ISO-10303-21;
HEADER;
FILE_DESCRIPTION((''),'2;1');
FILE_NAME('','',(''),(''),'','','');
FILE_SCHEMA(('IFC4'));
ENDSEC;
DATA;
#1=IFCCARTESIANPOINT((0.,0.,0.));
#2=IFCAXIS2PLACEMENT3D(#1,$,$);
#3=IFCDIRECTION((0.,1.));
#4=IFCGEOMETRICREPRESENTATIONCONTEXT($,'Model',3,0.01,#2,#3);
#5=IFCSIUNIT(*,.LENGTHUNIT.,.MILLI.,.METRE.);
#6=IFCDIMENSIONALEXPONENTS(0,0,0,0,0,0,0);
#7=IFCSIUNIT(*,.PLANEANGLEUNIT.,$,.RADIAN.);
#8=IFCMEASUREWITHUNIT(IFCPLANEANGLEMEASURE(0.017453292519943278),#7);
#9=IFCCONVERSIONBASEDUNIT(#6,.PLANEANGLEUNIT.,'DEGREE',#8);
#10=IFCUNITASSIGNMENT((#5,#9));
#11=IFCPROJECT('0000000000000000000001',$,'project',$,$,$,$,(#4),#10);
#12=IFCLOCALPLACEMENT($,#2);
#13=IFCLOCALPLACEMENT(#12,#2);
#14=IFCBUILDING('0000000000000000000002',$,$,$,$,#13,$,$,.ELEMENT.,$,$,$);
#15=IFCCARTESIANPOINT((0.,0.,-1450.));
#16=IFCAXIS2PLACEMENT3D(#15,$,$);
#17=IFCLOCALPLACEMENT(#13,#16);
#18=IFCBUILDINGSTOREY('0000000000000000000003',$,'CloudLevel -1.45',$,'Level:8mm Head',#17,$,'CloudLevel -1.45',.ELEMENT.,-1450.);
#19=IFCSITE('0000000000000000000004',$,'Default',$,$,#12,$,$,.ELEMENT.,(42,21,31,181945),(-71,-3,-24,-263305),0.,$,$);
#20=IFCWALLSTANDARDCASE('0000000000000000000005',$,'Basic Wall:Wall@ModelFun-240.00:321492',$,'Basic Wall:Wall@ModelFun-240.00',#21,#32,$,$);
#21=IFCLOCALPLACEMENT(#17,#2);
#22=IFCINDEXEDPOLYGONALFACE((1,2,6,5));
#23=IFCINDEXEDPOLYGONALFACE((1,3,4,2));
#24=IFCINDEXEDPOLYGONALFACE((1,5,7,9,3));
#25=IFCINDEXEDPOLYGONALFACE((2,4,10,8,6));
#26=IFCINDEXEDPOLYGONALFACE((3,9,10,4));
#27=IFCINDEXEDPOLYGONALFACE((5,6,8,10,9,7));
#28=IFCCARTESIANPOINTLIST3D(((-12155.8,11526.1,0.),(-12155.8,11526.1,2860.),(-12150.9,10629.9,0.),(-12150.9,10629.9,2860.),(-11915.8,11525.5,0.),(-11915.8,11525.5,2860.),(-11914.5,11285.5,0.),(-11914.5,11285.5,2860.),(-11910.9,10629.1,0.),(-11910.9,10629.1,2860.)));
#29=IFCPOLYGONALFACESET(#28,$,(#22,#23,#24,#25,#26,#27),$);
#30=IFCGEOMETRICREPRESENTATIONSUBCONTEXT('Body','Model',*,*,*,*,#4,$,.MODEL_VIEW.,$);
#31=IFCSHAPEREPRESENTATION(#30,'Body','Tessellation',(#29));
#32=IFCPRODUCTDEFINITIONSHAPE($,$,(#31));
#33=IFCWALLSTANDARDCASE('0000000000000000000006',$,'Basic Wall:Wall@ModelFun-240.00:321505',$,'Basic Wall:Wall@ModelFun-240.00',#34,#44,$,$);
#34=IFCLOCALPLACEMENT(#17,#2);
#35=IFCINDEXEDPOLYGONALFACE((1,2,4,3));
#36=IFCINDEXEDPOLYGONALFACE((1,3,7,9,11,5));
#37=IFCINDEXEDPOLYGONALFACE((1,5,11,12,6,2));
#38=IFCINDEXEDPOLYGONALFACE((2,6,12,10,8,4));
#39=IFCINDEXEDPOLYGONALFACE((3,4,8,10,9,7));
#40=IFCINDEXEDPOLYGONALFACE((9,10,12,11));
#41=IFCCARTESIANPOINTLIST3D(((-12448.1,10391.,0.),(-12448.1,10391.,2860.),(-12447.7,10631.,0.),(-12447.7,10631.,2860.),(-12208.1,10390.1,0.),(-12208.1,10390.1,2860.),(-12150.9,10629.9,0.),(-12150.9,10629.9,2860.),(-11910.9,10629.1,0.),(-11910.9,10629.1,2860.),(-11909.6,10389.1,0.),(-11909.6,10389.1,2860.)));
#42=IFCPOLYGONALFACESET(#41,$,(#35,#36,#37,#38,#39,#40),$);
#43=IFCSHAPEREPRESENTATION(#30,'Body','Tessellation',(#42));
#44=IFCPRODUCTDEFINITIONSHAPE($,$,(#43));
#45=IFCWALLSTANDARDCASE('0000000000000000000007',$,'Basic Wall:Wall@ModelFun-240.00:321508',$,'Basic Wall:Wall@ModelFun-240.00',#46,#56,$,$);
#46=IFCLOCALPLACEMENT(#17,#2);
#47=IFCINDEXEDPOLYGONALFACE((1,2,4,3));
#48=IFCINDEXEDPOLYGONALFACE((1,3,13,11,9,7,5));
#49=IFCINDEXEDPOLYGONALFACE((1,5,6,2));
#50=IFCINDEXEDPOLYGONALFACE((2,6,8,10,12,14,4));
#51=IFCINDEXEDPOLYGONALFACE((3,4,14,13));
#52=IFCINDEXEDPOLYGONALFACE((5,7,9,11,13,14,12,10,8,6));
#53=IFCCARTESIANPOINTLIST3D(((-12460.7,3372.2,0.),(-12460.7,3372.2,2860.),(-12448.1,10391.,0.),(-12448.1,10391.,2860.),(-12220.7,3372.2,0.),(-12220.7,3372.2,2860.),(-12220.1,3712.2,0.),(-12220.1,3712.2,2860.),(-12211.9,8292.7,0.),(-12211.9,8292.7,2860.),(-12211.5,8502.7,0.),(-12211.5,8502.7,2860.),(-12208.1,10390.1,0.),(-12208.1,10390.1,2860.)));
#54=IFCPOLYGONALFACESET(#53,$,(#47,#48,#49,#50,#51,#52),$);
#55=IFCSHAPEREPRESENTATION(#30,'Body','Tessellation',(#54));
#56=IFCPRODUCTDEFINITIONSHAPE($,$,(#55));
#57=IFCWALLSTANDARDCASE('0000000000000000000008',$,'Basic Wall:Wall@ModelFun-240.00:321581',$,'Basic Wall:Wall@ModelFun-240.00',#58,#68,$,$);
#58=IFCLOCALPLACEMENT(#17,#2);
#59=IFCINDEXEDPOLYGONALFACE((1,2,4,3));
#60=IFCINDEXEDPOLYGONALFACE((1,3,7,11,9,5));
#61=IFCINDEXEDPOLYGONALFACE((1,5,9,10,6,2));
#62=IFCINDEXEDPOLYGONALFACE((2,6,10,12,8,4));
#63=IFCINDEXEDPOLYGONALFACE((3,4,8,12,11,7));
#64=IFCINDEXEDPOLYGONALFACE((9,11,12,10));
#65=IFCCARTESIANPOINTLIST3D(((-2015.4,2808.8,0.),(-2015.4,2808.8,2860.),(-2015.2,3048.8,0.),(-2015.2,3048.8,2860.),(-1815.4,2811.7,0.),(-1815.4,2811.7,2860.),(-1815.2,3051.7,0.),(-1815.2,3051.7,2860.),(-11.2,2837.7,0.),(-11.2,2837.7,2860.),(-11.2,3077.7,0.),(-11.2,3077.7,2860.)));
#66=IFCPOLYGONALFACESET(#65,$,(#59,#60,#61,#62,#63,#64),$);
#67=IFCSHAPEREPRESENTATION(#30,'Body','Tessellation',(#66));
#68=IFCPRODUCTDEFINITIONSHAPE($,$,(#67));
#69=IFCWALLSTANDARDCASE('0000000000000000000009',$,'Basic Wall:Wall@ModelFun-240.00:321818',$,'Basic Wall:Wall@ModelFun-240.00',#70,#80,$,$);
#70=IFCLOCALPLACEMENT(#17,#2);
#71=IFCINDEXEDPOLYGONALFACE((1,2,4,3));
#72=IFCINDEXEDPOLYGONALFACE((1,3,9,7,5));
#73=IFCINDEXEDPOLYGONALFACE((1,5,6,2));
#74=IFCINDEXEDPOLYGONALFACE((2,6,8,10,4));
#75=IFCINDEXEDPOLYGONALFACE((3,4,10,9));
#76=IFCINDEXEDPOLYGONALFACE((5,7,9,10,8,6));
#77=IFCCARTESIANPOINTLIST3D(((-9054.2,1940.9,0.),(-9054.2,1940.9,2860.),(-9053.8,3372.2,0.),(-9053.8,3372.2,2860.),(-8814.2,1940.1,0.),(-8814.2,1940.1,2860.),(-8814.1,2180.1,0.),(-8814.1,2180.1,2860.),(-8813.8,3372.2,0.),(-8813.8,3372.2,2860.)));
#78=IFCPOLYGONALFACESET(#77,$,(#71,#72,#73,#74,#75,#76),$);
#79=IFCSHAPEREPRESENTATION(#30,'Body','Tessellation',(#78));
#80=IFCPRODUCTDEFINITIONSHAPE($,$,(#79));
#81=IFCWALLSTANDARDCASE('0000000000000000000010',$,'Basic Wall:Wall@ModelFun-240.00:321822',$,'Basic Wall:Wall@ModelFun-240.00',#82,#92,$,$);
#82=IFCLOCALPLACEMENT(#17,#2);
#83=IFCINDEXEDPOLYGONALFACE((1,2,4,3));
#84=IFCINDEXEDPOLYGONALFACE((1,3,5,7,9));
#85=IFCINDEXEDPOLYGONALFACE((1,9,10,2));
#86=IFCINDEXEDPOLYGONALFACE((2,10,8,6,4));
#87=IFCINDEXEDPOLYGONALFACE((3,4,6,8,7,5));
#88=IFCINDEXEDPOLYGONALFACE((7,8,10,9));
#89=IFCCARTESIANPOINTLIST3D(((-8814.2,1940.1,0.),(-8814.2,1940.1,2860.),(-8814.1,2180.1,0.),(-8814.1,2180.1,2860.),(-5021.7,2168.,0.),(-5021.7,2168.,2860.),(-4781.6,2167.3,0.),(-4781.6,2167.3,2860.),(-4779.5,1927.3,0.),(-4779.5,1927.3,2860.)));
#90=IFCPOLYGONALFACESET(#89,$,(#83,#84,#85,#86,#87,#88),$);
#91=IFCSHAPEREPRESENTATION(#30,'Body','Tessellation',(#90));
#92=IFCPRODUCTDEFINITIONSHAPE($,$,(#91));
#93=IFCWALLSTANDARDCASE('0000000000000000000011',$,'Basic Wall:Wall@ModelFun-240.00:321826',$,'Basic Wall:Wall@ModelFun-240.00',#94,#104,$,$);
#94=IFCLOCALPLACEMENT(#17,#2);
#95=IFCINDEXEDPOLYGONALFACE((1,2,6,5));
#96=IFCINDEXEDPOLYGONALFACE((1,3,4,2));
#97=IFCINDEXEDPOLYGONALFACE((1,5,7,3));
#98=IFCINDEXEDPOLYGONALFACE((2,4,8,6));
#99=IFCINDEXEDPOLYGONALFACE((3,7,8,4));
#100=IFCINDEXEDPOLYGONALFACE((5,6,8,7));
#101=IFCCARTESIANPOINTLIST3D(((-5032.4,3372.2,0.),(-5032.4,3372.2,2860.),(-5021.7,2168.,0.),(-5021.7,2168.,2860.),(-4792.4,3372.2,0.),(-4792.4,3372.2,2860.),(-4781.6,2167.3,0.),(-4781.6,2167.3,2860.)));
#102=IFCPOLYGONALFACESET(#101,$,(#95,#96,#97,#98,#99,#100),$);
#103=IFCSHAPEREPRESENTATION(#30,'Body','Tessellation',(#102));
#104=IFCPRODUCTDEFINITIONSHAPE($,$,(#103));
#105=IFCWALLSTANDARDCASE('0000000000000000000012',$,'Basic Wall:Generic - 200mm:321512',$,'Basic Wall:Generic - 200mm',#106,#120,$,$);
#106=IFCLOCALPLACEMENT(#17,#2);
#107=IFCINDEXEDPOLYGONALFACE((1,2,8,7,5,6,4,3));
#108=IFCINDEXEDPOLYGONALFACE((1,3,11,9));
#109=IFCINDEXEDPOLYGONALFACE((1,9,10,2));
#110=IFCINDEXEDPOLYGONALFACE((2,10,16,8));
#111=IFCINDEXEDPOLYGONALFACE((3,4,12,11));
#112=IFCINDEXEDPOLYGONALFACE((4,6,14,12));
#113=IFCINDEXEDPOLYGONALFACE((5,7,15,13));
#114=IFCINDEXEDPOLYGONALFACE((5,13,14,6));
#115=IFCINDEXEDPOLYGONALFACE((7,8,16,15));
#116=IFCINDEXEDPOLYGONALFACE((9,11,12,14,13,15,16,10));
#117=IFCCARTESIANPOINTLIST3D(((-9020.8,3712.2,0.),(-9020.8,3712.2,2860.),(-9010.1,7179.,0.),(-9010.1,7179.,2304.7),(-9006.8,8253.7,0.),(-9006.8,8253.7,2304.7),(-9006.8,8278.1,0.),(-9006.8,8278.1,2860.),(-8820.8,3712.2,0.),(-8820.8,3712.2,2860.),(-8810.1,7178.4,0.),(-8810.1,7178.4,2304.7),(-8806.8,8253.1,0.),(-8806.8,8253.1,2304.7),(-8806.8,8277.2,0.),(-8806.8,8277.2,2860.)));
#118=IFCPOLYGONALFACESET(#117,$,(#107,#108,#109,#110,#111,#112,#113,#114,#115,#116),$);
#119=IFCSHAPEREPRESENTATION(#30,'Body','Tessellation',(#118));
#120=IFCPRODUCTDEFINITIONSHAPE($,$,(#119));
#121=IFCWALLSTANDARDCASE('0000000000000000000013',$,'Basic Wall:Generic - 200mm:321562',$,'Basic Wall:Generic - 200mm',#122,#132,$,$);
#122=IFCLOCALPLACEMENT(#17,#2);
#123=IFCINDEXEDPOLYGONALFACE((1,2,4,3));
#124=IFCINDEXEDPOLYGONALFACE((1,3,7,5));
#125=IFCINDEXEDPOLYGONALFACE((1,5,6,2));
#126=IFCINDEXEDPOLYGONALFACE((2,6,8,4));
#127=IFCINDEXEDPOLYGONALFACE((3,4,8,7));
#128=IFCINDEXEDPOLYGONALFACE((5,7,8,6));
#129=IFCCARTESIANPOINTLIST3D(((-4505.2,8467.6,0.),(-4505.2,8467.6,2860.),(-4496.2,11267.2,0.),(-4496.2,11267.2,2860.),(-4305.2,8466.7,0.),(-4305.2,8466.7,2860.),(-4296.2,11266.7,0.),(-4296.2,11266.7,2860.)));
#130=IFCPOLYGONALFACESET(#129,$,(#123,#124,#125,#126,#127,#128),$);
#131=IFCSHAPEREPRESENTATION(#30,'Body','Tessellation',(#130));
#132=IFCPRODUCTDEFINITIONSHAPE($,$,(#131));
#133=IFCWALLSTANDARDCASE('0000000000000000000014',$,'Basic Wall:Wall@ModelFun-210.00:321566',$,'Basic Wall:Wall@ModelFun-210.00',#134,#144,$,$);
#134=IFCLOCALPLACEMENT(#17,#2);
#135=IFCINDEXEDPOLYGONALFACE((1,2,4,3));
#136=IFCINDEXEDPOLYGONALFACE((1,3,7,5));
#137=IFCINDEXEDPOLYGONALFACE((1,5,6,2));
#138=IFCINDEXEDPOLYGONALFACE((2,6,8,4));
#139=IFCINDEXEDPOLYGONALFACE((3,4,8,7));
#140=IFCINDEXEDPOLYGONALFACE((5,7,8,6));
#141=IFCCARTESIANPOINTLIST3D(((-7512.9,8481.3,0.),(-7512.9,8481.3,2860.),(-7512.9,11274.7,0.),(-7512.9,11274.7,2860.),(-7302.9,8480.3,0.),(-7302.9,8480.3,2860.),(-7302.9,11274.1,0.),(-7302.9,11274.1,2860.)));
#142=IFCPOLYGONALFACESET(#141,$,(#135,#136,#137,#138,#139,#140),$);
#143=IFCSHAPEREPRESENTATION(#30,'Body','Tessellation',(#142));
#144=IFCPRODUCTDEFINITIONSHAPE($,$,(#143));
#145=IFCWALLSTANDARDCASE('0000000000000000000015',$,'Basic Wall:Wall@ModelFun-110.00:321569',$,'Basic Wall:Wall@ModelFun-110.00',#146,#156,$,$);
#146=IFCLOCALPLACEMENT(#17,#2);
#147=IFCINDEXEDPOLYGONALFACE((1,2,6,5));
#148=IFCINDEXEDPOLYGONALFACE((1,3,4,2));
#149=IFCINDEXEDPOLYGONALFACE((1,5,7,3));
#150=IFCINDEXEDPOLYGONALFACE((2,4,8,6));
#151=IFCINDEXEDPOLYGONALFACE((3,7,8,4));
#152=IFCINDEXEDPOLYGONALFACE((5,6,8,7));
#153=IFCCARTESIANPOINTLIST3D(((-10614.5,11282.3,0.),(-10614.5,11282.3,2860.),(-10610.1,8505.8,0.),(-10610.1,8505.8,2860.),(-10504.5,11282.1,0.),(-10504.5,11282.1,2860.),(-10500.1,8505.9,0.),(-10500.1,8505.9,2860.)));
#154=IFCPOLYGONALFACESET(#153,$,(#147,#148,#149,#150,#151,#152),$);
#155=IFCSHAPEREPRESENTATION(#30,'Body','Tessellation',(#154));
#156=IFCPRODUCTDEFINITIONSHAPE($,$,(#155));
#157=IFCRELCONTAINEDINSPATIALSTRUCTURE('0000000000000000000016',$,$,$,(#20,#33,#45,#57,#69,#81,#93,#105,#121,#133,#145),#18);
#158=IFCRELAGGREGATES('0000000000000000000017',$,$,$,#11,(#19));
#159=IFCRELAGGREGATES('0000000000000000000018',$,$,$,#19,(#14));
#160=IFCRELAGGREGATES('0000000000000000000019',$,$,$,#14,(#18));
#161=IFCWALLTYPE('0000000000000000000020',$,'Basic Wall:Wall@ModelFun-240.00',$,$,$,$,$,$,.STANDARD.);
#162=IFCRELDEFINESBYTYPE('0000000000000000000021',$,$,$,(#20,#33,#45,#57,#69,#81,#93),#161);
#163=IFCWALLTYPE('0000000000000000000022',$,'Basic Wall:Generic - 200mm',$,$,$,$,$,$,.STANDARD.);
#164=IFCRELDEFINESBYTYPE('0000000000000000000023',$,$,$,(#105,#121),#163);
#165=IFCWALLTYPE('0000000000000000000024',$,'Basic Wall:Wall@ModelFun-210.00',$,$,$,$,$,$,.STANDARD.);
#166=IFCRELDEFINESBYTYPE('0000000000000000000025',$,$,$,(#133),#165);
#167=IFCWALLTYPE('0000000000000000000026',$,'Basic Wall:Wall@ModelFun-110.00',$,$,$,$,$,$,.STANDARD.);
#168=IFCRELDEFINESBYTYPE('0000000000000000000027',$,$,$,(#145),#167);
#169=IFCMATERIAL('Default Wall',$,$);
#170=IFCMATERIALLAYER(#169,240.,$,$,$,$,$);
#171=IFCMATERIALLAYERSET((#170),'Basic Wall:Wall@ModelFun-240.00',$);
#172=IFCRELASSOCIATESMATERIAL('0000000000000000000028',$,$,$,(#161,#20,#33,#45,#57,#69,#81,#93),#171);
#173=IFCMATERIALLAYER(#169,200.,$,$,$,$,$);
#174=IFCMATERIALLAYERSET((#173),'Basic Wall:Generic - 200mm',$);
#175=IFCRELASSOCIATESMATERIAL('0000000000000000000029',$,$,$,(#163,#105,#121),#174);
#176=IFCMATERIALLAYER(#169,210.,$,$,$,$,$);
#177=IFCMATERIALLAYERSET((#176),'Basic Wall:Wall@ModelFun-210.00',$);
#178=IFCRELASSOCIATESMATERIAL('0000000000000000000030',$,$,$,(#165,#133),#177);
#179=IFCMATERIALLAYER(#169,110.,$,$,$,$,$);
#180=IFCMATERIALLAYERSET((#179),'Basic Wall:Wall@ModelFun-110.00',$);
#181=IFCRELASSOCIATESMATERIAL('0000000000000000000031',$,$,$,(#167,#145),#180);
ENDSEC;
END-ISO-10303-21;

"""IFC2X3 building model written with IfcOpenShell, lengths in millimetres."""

from ifc_helpers import new_model, entity, si_unit, converted_unit, direction, frame, frame_2d, origin, place, context, subcontext, project, spatial, polyline, rectangle, outline, extrude, material, layer, layer_set, layer_usage, type_object, element, save


model = new_model("IFC2X3")

# Units and contexts
model_context = context("Model", 3, precision=0.01, world=origin(), true_north=direction((0.0, 1.0)))
body_context = subcontext(model_context, "Body", "Model", "MODEL_VIEW")
ifc_project = project(units=[si_unit("LENGTHUNIT", "METRE", prefix="MILLI"), converted_unit("PLANEANGLEUNIT", "DEGREE", entity("IfcPlaneAngleMeasure", 0.017453292519943278), si_unit("PLANEANGLEUNIT", "RADIAN"), dimensions=[0, 0, 0, 0, 0, 0, 0])], contexts=[model_context])

# Site, building, storey
site_placement = place(None, origin())
site = spatial("IfcSite", under=ifc_project, at=site_placement, Name="Default", CompositionType="ELEMENT", RefLatitude=(42, 21, 31, 181945), RefLongitude=(-71, -3, -24, -263305), RefElevation=0.0)
building_placement = place(site_placement, origin())
building = spatial("IfcBuilding", under=site, at=building_placement, CompositionType="ELEMENT")
storey_placement = place(building_placement, frame((0.0, 0.0, -1450.0)))
storey = spatial("IfcBuildingStorey", under=building, at=storey_placement, Name="CloudLevel -1.45", ObjectType="Level:8mm Head", LongName="CloudLevel -1.45", CompositionType="ELEMENT", Elevation=-1450.0)

# Walls
ifc_material_1 = material(Name="Default Wall")
ifc_layer_1 = layer(ifc_material_1, 240.0)
ifc_layer_set_1 = layer_set([ifc_layer_1], Name="Basic Wall:Wall@ModelFun-240.00")
ifc_layer_usage_1 = layer_usage(ifc_layer_set_1, "AXIS2", "NEGATIVE", 120.0)
wall_type_1 = type_object("IfcWallType", Name="Basic Wall:Wall@ModelFun-240.00", PredefinedType="STANDARD", material=ifc_layer_set_1)
wall_1_placement = place(storey_placement, frame((-12035.8, 11526.8, 0.0), z_axis=(0.0, 0.0, 1.0), x_axis=(0.005403, -0.999985, 0.0)))
element("IfcWallStandardCase", 1, at=wall_1_placement, inside=storey, type_object=wall_type_1, material=ifc_layer_usage_1, Name="Basic Wall:Wall@ModelFun-240.00:321492", ObjectType="Basic Wall:Wall@ModelFun-240.00", context=body_context, shape_type="SweptSolid", body=[
    extrude(outline(polyline([(896.2, -120.0), (898.4, 120.0), (241.9, 120.0), (1.9, 120.0), (0.0, -120.0), (896.2, -120.0)])), origin(), (0.0, 0.0, 1.0), 2860.0),
])
wall_2_placement = place(storey_placement, frame((-11909.2, 10509.0, 0.0), z_axis=(0.0, 0.0, 1.0), x_axis=(-0.999994, 0.003528, 0.0)))
element("IfcWallStandardCase", 2, at=wall_2_placement, inside=storey, type_object=wall_type_1, material=ifc_layer_usage_1, Name="Basic Wall:Wall@ModelFun-240.00:321505", ObjectType="Basic Wall:Wall@ModelFun-240.00", context=body_context, shape_type="SweptSolid", body=[
    extrude(outline(polyline([(538.9, -120.0), (538.5, 120.0), (298.5, 120.0), (0.0, 120.0), (2.1, -120.0), (242.2, -120.0), (538.9, -120.0)])), origin(), (0.0, 0.0, 1.0), 2860.0),
])
wall_3_placement = place(storey_placement, frame((-12328.1, 10390.7, 0.0), z_axis=(0.0, 0.0, 1.0), x_axis=(-0.001796, -0.999998, 0.0)))
element("IfcWallStandardCase", 3, at=wall_3_placement, inside=storey, type_object=wall_type_1, material=ifc_layer_usage_1, Name="Basic Wall:Wall@ModelFun-240.00:321508", ObjectType="Basic Wall:Wall@ModelFun-240.00", context=body_context, shape_type="SweptSolid", body=[
    extrude(outline(polyline([(7018.7, -120.0), (7018.3, 120.0), (6678.3, 120.0), (2097.8, 120.0), (1887.8, 120.0), (0.4, 120.0), (0.0, -120.0), (7018.7, -120.0)])), origin(), (0.0, 0.0, 1.0), 2860.0),
])
wall_4_placement = place(storey_placement, frame((-2017.1, 2928.8, 0.0), z_axis=(0.0, 0.0, 1.0), x_axis=(0.999896, 0.014403, 0.0)))
element("IfcWallStandardCase", 4, at=wall_4_placement, inside=storey, type_object=wall_type_1, material=ifc_layer_usage_1, Name="Basic Wall:Wall@ModelFun-240.00:321581", ObjectType="Basic Wall:Wall@ModelFun-240.00", context=body_context, shape_type="SweptSolid", body=[
    extrude(outline(polyline([(2004.4, -120.0), (2007.9, 120.0), (203.7, 120.0), (3.6, 120.0), (0.0, -120.0), (200.0, -120.0), (2004.4, -120.0)])), origin(), (0.0, 0.0, 1.0), 2860.0),
])
wall_5_placement = place(storey_placement, frame((-8934.2, 1940.1, 0.0), z_axis=(0.0, 0.0, 1.0), x_axis=(0.000306, 1.0, 0.0)))
element("IfcWallStandardCase", 5, at=wall_5_placement, inside=storey, type_object=wall_type_1, material=ifc_layer_usage_1, Name="Basic Wall:Wall@ModelFun-240.00:321818", ObjectType="Basic Wall:Wall@ModelFun-240.00", context=body_context, shape_type="SweptSolid", body=[
    extrude(outline(polyline([(1432.1, -120.0), (1432.1, 120.0), (0.7, 120.0), (0.0, -120.0), (240.0, -120.0), (1432.1, -120.0)])), origin(), (0.0, 0.0, 1.0), 2860.0),
])
wall_6_placement = place(storey_placement, frame((-4779.1, 2047.3, 0.0), z_axis=(0.0, 0.0, 1.0), x_axis=(-0.999995, 0.003182, 0.0)))
element("IfcWallStandardCase", 6, at=wall_6_placement, inside=storey, type_object=wall_type_1, material=ifc_layer_usage_1, Name="Basic Wall:Wall@ModelFun-240.00:321822", ObjectType="Basic Wall:Wall@ModelFun-240.00", context=body_context, shape_type="SweptSolid", body=[
    extrude(outline(polyline([(4035.4, -120.0), (4034.7, 120.0), (0.0, 120.0), (2.9, -120.0), (242.9, -120.0), (4035.4, -120.0)])), origin(), (0.0, 0.0, 1.0), 2860.0),
])
wall_7_placement = place(storey_placement, frame((-4912.4, 3373.3, 0.0), z_axis=(0.0, 0.0, 1.0), x_axis=(0.008938, -0.99996, 0.0)))
element("IfcWallStandardCase", 7, at=wall_7_placement, inside=storey, type_object=wall_type_1, material=ifc_layer_usage_1, Name="Basic Wall:Wall@ModelFun-240.00:321826", ObjectType="Basic Wall:Wall@ModelFun-240.00", context=body_context, shape_type="SweptSolid", body=[
    extrude(outline(polyline([(1204.2, -120.0), (1207.2, 120.0), (2.1, 120.0), (0.0, -120.0), (1204.2, -120.0)])), origin(), (0.0, 0.0, 1.0), 2860.0),
])

# Wall, opening
ifc_layer_2 = layer(ifc_material_1, 200.0)
ifc_layer_set_2 = layer_set([ifc_layer_2], Name="Basic Wall:Generic - 200mm")
ifc_layer_usage_2 = layer_usage(ifc_layer_set_2, "AXIS2", "NEGATIVE", 100.0)
wall_type_2 = type_object("IfcWallType", Name="Basic Wall:Generic - 200mm", PredefinedType="STANDARD", material=ifc_layer_set_2)
wall_8_placement = place(storey_placement, frame((-8920.8, 3711.9, 0.0), z_axis=(0.0, 0.0, 1.0), x_axis=(0.003071, 0.999995, 0.0)))
wall_8 = element("IfcWallStandardCase", 8, at=wall_8_placement, inside=storey, type_object=wall_type_2, material=ifc_layer_usage_2, Name="Basic Wall:Generic - 200mm:321512", ObjectType="Basic Wall:Generic - 200mm", context=body_context, shape_type="SweptSolid", body=[
    extrude(outline(polyline([(0.6, -100.0), (4565.6, -100.0), (4565.9, 100.0), (0.0, 100.0), (0.6, -100.0)])), origin(), (0.0, 0.0, 1.0), 2860.0),
])
opening_1_placement = place(wall_8_placement, frame((3466.8, -100.0, 0.0)))
element("IfcOpeningElement", 9, at=opening_1_placement, cuts=wall_8, ObjectType="Opening", context=body_context, shape_type="SweptSolid", body=[
    extrude(rectangle(XDim=1074.7, YDim=2304.7, at=frame_2d((1152.4, 537.4), x_axis=(0.0, 1.0))), frame((0.0, 0.0, 0.0), z_axis=(0.0, 1.0, 0.0), x_axis=(0.0, 0.0, 1.0)), (0.0, 0.0, 1.0), 200.0),
])

# Wall
wall_9_placement = place(storey_placement, frame((-4396.2, 11267.0, 0.0), z_axis=(0.0, 0.0, 1.0), x_axis=(-0.003206, -0.999995, 0.0)))
element("IfcWallStandardCase", 10, at=wall_9_placement, inside=storey, type_object=wall_type_2, material=ifc_layer_usage_2, Name="Basic Wall:Generic - 200mm:321562", ObjectType="Basic Wall:Generic - 200mm", context=body_context, shape_type="SweptSolid", body=[
    extrude(outline(polyline([(2799.8, -100.0), (2800.0, 100.0), (0.0, 100.0), (0.1, -100.0), (2799.8, -100.0)])), origin(), (0.0, 0.0, 1.0), 2860.0),
])

# Walls
ifc_layer_3 = layer(ifc_material_1, 210.0)
ifc_layer_set_3 = layer_set([ifc_layer_3], Name="Basic Wall:Wall@ModelFun-210.00")
ifc_layer_usage_3 = layer_usage(ifc_layer_set_3, "AXIS2", "NEGATIVE", 105.0)
wall_type_3 = type_object("IfcWallType", Name="Basic Wall:Wall@ModelFun-210.00", PredefinedType="STANDARD", material=ifc_layer_set_3)
wall_10_placement = place(storey_placement, frame((-7407.9, 8480.3, 0.0), z_axis=(0.0, 0.0, 1.0), x_axis=(0.0, 1.0, 0.0)))
element("IfcWallStandardCase", 11, at=wall_10_placement, inside=storey, type_object=wall_type_3, material=ifc_layer_usage_3, Name="Basic Wall:Wall@ModelFun-210.00:321566", ObjectType="Basic Wall:Wall@ModelFun-210.00", context=body_context, shape_type="SweptSolid", body=[
    extrude(outline(polyline([(2793.8, -105.0), (2794.3, 105.0), (1.0, 105.0), (0.0, -105.0), (2793.8, -105.0)])), origin(), (0.0, 0.0, 1.0), 2860.0),
])
ifc_layer_4 = layer(ifc_material_1, 110.0)
ifc_layer_set_4 = layer_set([ifc_layer_4], Name="Basic Wall:Wall@ModelFun-110.00")
ifc_layer_usage_4 = layer_usage(ifc_layer_set_4, "AXIS2", "NEGATIVE", 55.0)
wall_type_4 = type_object("IfcWallType", Name="Basic Wall:Wall@ModelFun-110.00", PredefinedType="STANDARD", material=ifc_layer_set_4)
wall_11_placement = place(storey_placement, frame((-10555.1, 8505.8, 0.0), z_axis=(0.0, 0.0, 1.0), x_axis=(-0.00156, 0.999999, 0.0)))
element("IfcWallStandardCase", 12, at=wall_11_placement, inside=storey, type_object=wall_type_4, material=ifc_layer_usage_4, Name="Basic Wall:Wall@ModelFun-110.00:321569", ObjectType="Basic Wall:Wall@ModelFun-110.00", context=body_context, shape_type="SweptSolid", body=[
    extrude(outline(polyline([(2776.1, -55.0), (2776.6, 55.0), (0.0, 55.0), (0.0, -55.0), (2776.1, -55.0)])), origin(), (0.0, 0.0, 1.0), 2860.0),
])

save(model, "model.ifc")
